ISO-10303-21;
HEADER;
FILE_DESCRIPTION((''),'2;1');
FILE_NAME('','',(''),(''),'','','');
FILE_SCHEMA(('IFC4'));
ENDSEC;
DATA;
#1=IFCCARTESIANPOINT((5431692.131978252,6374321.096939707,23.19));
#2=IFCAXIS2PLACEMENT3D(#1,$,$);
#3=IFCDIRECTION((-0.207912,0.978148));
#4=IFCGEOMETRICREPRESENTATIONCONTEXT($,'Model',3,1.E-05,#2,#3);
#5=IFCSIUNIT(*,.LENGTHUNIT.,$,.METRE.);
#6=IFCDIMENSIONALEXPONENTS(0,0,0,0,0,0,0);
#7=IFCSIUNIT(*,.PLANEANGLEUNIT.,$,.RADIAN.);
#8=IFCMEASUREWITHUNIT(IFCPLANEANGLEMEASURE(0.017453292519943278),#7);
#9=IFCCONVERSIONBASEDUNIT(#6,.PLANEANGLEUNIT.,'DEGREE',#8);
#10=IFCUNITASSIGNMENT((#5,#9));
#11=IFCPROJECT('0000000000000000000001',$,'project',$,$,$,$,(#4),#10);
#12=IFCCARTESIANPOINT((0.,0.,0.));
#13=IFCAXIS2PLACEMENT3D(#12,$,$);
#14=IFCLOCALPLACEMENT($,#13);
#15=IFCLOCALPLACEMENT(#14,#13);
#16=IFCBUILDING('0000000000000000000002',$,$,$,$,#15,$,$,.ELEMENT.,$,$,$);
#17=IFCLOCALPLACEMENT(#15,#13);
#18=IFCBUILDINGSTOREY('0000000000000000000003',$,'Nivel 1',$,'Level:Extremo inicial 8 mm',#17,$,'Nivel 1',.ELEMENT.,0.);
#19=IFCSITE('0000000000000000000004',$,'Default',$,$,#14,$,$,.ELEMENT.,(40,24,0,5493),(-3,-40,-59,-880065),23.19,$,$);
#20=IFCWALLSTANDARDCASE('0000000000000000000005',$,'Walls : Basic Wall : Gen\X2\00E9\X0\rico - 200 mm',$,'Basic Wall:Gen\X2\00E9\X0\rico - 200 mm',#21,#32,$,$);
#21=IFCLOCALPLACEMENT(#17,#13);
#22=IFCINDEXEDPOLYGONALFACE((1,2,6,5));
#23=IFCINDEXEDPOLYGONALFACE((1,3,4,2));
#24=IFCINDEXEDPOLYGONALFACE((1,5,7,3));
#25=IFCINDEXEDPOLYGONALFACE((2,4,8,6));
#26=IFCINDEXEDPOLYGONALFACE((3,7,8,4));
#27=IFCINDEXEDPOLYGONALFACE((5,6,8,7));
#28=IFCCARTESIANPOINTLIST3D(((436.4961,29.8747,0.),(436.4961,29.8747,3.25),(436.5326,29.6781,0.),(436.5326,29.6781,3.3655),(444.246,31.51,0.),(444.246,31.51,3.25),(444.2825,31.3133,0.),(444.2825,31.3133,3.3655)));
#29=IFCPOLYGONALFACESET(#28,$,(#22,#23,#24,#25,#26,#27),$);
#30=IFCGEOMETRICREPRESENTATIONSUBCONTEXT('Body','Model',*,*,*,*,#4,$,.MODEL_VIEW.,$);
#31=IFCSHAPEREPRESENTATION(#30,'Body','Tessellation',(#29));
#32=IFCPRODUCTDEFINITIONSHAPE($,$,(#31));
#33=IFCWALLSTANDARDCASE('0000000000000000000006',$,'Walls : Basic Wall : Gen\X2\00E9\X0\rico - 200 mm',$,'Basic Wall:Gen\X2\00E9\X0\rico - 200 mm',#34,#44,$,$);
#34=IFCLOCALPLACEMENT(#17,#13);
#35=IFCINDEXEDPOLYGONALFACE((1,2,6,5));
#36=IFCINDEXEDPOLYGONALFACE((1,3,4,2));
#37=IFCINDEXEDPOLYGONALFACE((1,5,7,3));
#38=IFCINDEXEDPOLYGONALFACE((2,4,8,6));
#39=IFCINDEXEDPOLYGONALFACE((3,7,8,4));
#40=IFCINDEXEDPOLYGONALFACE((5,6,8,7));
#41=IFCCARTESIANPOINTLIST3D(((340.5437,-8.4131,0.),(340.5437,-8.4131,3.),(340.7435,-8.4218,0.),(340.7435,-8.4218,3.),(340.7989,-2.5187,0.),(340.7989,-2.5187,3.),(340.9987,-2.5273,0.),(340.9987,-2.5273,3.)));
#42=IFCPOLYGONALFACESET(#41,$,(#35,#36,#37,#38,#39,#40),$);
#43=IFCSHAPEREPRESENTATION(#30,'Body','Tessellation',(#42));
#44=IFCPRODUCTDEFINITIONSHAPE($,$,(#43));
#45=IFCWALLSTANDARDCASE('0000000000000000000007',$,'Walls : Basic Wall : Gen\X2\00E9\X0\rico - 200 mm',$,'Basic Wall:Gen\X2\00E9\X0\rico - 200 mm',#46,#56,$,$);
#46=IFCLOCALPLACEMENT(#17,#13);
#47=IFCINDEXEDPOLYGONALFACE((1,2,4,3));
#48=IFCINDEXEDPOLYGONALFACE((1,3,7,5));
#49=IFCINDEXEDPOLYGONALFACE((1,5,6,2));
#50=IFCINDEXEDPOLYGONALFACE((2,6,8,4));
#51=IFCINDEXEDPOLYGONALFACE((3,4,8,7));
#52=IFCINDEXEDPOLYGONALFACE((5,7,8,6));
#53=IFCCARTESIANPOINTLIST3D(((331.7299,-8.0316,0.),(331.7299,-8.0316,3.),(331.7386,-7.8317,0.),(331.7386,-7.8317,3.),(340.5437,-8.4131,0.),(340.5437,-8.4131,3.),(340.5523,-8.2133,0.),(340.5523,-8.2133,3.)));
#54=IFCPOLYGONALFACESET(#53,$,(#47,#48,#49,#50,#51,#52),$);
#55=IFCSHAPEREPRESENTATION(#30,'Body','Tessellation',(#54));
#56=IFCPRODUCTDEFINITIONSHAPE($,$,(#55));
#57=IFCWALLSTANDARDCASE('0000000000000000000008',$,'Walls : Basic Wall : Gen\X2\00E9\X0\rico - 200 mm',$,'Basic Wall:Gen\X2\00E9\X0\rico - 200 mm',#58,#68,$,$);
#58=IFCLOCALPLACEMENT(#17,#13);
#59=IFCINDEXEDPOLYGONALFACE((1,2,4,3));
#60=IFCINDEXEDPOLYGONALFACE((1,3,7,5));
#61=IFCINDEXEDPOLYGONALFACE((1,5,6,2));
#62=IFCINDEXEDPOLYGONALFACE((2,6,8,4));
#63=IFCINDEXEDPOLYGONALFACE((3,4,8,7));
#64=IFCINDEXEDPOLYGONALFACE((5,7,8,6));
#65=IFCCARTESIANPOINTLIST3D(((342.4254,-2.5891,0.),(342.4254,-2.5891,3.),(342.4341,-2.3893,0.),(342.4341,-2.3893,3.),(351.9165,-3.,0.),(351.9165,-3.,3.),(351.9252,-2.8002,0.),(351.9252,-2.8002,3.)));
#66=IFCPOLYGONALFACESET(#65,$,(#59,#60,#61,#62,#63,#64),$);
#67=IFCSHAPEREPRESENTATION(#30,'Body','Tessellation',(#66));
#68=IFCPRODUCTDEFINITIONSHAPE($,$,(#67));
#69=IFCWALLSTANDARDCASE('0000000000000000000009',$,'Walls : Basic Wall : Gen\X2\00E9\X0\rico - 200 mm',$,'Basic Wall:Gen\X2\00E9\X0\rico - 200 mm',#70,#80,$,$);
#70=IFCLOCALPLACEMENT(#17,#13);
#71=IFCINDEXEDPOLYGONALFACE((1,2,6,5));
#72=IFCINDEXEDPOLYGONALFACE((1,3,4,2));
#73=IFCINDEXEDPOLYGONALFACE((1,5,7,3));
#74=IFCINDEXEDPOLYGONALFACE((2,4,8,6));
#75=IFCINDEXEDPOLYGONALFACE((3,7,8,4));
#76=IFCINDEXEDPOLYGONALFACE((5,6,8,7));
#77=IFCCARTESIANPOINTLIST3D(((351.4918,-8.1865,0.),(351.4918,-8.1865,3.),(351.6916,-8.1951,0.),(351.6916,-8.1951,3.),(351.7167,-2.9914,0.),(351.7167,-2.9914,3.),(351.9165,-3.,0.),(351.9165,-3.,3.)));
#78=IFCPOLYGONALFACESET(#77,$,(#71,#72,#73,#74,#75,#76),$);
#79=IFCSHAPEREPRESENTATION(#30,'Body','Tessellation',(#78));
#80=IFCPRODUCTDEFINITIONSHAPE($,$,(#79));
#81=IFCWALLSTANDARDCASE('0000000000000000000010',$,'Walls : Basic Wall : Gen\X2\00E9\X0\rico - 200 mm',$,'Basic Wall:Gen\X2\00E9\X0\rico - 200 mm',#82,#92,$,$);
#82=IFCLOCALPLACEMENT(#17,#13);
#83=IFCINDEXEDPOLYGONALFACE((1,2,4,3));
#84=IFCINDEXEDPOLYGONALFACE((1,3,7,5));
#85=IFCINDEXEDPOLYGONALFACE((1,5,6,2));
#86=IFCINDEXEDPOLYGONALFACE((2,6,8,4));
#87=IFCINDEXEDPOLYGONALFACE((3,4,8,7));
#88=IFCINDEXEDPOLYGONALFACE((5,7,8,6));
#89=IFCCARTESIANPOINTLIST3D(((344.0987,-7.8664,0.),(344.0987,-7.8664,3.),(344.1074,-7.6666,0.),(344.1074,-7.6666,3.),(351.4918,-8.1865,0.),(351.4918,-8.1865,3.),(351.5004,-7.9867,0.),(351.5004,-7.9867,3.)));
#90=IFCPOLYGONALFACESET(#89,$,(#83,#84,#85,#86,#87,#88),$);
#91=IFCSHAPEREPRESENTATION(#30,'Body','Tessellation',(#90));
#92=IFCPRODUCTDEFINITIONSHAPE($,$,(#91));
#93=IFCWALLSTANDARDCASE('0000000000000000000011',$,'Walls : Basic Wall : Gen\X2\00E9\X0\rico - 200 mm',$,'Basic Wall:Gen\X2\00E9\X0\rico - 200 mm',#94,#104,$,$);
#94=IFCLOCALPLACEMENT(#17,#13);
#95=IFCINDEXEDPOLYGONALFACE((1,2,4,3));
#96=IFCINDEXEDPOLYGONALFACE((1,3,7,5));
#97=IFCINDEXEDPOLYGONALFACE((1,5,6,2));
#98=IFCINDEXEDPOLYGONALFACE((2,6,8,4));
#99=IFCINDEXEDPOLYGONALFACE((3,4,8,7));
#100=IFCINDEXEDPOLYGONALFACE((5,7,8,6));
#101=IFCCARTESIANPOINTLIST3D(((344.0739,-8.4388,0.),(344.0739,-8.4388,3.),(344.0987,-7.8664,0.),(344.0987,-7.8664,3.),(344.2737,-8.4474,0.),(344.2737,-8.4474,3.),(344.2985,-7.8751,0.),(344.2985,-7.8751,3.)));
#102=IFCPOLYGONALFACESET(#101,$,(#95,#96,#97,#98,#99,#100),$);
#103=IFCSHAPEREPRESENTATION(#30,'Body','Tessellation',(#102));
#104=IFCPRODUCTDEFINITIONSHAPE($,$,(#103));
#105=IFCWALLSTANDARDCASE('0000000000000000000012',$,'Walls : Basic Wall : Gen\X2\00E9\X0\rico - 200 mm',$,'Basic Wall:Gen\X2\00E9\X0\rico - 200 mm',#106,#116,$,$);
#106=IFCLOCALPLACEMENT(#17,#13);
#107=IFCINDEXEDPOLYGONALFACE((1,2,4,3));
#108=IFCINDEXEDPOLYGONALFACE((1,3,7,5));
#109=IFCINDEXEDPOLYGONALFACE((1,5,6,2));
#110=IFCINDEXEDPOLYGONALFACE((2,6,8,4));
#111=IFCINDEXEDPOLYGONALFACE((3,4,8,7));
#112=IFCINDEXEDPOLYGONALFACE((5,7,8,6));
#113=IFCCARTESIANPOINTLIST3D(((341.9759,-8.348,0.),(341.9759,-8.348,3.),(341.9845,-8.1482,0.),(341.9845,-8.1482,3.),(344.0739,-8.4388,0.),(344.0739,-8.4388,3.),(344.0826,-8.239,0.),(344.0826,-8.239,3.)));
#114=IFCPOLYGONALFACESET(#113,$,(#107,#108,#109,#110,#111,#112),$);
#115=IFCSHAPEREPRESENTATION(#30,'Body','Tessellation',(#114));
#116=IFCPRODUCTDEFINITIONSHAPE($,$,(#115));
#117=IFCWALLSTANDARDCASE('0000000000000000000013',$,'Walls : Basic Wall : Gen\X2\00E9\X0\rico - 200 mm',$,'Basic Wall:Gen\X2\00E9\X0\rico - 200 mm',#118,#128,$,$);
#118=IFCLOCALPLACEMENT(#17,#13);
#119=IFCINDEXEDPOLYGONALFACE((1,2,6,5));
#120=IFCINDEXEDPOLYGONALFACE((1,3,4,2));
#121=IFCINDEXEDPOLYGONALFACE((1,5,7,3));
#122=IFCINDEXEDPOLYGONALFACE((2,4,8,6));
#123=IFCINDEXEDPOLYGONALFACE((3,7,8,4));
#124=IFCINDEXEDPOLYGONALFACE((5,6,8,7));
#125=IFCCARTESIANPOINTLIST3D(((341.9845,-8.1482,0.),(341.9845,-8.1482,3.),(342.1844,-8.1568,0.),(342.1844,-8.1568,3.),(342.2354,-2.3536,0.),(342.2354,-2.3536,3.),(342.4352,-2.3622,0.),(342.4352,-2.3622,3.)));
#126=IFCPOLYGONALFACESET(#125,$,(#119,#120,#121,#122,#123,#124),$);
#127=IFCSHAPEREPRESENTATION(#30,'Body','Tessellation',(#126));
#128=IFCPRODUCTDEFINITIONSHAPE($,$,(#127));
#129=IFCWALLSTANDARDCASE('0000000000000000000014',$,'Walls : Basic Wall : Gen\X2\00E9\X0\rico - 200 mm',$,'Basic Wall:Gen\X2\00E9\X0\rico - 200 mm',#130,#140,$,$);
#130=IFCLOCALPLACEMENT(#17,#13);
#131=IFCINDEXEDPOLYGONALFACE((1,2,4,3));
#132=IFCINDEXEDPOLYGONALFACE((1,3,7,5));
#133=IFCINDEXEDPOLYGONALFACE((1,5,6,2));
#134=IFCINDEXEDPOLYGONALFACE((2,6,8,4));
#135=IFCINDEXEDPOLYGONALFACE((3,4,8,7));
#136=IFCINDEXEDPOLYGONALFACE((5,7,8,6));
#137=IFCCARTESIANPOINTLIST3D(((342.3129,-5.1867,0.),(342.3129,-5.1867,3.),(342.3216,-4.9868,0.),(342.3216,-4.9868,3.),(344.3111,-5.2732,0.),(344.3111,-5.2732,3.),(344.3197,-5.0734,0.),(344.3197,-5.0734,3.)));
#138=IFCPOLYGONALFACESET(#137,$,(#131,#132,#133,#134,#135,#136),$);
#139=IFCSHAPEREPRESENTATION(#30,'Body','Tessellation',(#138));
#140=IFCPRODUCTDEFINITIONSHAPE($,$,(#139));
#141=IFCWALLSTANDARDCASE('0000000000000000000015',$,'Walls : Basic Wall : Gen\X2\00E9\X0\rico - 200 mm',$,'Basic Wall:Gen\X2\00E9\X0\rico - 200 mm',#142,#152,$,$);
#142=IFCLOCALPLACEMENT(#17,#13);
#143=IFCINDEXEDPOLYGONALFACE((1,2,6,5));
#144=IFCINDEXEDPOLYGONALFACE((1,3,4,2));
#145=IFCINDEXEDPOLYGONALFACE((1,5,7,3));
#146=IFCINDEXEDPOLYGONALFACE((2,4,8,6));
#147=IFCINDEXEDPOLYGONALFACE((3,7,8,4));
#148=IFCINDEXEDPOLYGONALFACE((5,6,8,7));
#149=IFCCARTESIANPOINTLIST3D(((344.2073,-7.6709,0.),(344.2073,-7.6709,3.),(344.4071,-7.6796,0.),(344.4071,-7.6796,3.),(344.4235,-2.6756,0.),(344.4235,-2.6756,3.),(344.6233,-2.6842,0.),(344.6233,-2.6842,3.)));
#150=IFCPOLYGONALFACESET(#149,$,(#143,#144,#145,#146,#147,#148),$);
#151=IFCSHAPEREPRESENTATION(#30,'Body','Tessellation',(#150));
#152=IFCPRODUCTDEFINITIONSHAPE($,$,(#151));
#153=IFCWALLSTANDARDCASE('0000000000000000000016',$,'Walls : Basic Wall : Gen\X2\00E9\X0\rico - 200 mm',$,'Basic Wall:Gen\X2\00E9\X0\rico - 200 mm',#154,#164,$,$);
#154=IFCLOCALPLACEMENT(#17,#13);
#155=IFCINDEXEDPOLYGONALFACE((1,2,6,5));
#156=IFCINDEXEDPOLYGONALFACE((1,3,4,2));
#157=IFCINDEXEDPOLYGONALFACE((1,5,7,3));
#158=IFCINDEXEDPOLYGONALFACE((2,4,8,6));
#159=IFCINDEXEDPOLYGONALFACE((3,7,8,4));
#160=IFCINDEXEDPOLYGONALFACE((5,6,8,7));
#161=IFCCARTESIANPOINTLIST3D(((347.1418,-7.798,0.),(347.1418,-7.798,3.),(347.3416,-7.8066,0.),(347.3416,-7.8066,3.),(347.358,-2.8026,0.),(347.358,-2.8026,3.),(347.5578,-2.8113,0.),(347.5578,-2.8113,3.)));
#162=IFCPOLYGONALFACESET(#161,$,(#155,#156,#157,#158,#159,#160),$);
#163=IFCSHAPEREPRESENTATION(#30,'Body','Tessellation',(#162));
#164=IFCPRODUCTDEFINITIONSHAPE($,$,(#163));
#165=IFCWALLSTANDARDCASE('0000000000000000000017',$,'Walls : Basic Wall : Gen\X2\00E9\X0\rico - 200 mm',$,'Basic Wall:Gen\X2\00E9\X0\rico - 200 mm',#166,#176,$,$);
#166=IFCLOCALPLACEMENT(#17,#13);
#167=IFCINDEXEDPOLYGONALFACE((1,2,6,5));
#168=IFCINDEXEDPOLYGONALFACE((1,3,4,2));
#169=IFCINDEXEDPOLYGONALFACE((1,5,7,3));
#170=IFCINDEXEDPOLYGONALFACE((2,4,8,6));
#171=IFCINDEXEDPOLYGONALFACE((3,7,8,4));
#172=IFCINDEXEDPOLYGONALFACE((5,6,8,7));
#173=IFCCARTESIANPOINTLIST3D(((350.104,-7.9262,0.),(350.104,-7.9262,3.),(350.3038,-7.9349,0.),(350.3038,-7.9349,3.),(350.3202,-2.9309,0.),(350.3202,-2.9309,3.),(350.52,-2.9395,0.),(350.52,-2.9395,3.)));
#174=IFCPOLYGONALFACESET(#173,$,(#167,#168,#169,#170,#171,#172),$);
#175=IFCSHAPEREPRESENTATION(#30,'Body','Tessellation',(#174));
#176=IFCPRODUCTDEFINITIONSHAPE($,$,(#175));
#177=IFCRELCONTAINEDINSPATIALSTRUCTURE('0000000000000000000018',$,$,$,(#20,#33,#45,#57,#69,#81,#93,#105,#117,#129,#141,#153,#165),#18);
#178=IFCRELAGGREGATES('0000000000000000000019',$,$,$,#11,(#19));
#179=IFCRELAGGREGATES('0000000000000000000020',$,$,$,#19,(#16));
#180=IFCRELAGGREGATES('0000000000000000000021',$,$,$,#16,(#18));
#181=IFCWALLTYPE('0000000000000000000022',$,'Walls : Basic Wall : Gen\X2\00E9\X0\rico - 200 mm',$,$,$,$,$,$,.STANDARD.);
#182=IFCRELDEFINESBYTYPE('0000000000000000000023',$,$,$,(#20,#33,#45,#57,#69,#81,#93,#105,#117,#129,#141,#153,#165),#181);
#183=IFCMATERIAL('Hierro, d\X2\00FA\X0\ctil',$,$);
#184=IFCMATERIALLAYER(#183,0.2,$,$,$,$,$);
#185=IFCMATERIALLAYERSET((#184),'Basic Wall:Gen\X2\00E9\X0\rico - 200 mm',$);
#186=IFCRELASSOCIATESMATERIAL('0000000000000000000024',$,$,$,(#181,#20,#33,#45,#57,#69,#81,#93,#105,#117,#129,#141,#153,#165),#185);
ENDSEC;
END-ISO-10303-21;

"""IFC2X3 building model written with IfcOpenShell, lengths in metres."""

from ifc_helpers import new_model, entity, si_unit, converted_unit, direction, frame, frame_2d, origin, place, context, subcontext, project, spatial, polyline, rectangle, outline, extrude, clip, bounded_halfspace, material, layer, layer_set, layer_usage, type_object, element, save


model = new_model("IFC2X3")

# Units and contexts
model_context = context("Model", 3, precision=1e-05, world=frame((5431692.131978252, 6374321.096939707, 23.19)), true_north=direction((-0.207912, 0.978148)))
body_context = subcontext(model_context, "Body", "Model", "MODEL_VIEW")
ifc_project = project(units=[si_unit("LENGTHUNIT", "METRE"), converted_unit("PLANEANGLEUNIT", "DEGREE", entity("IfcPlaneAngleMeasure", 0.017453292519943278), si_unit("PLANEANGLEUNIT", "RADIAN"), dimensions=[0, 0, 0, 0, 0, 0, 0])], contexts=[model_context])

# Site, building, storey
site_placement = place(None, origin())
site = spatial("IfcSite", under=ifc_project, at=site_placement, Name="Default", CompositionType="ELEMENT", RefLatitude=(40, 24, 0, 5493), RefLongitude=(-3, -40, -59, -880065), RefElevation=23.19)
building_placement = place(site_placement, origin())
building = spatial("IfcBuilding", under=site, at=building_placement, CompositionType="ELEMENT")
storey_placement = place(building_placement, origin())
storey = spatial("IfcBuildingStorey", under=building, at=storey_placement, Name="Nivel 1", ObjectType="Level:Extremo inicial 8 mm", LongName="Nivel 1", CompositionType="ELEMENT", Elevation=0.0)

# Walls
ifc_material_1 = material(Name="Hierro, dúctil")
ifc_layer_1 = layer(ifc_material_1, 0.2)
ifc_layer_set_1 = layer_set([ifc_layer_1], Name="Basic Wall:Genérico - 200 mm")
ifc_layer_usage_1 = layer_usage(ifc_layer_set_1, "AXIS2", "NEGATIVE", 0.1)
wall_type = type_object("IfcWallType", Name="Walls : Basic Wall : Genérico - 200 mm", PredefinedType="STANDARD", material=ifc_layer_set_1)
wall_1_placement = place(storey_placement, frame((436.512, 29.7759, 0.0), z_axis=(0.0, 0.0, 1.0), x_axis=(0.978457, 0.206451, 0.0)))
element("IfcWallStandardCase", 1, at=wall_1_placement, inside=storey, type_object=wall_type, material=ifc_layer_usage_1, Name="Walls : Basic Wall : Genérico - 200 mm", ObjectType="Basic Wall:Genérico - 200 mm", context=body_context, shape_type="Clipping", body=[
    clip(extrude(outline(polyline([(7.9205, -0.1), (7.9254, 0.1), (0.0049, 0.1), (0.0, -0.1), (7.7205, -0.1), (7.9205, -0.1)])), origin(), (0.0, 0.0, 1.0), 3.3655), bounded_halfspace(frame((0.0, -0.1, 3.3655), z_axis=(0.0, 0.5, 0.866025), x_axis=(-1.0, 0.0, 0.0)), False, frame((0.0, -0.1, 3.3655)), polyline([(0.0, 0.0), (7.7205, 0.0), (7.9205, 0.0), (7.9254, 0.2), (0.0049, 0.2), (0.0, 0.0)]))),
])
ifc_layer_usage_2 = layer_usage(ifc_layer_set_1, "AXIS2", "NEGATIVE", 0.1)
wall_2_placement = place(storey_placement, frame((340.8988, -2.523, 0.0), z_axis=(0.0, 0.0, 1.0), x_axis=(-0.043255, -0.999064, 0.0)))
element("IfcWallStandardCase", 2, at=wall_2_placement, inside=storey, type_object=wall_type, material=ifc_layer_usage_2, Name="Walls : Basic Wall : Genérico - 200 mm", ObjectType="Basic Wall:Genérico - 200 mm", context=body_context, shape_type="SweptSolid", body=[
    extrude(rectangle(XDim=5.9, YDim=0.2, at=frame_2d((2.95, 0.0), x_axis=(-1.0, 0.0))), origin(), (0.0, 0.0, 1.0), 3.0),
])
ifc_layer_usage_3 = layer_usage(ifc_layer_set_1, "AXIS2", "NEGATIVE", 0.1)
wall_3_placement = place(storey_placement, frame((340.548, -8.3132, 0.0), z_axis=(0.0, 0.0, 1.0), x_axis=(-0.999064, 0.043255, 0.0)))
element("IfcWallStandardCase", 3, at=wall_3_placement, inside=storey, type_object=wall_type, material=ifc_layer_usage_3, Name="Walls : Basic Wall : Genérico - 200 mm", ObjectType="Basic Wall:Genérico - 200 mm", context=body_context, shape_type="SweptSolid", body=[
    extrude(rectangle(XDim=8.822, YDim=0.2, at=frame_2d((4.411, 0.0), x_axis=(-1.0, 0.0))), origin(), (0.0, 0.0, 1.0), 3.0),
])
ifc_layer_usage_4 = layer_usage(ifc_layer_set_1, "AXIS2", "NEGATIVE", 0.1)
wall_4_placement = place(storey_placement, frame((342.4297, -2.4892, 0.0), z_axis=(0.0, 0.0, 1.0), x_axis=(0.999064, -0.043255, 0.0)))
element("IfcWallStandardCase", 4, at=wall_4_placement, inside=storey, type_object=wall_type, material=ifc_layer_usage_4, Name="Walls : Basic Wall : Genérico - 200 mm", ObjectType="Basic Wall:Genérico - 200 mm", context=body_context, shape_type="SweptSolid", body=[
    extrude(rectangle(XDim=9.5, YDim=0.2, at=frame_2d((4.75, 0.0), x_axis=(-1.0, 0.0))), origin(), (0.0, 0.0, 1.0), 3.0),
])
ifc_layer_usage_5 = layer_usage(ifc_layer_set_1, "AXIS2", "NEGATIVE", 0.1)
wall_5_placement = place(storey_placement, frame((351.8166, -2.9957, 0.0), z_axis=(0.0, 0.0, 1.0), x_axis=(-0.043255, -0.999064, 0.0)))
element("IfcWallStandardCase", 5, at=wall_5_placement, inside=storey, type_object=wall_type, material=ifc_layer_usage_5, Name="Walls : Basic Wall : Genérico - 200 mm", ObjectType="Basic Wall:Genérico - 200 mm", context=body_context, shape_type="SweptSolid", body=[
    extrude(rectangle(XDim=5.2, YDim=0.2, at=frame_2d((2.6, 0.0), x_axis=(-1.0, 0.0))), origin(), (0.0, 0.0, 1.0), 3.0),
])
ifc_layer_usage_6 = layer_usage(ifc_layer_set_1, "AXIS2", "NEGATIVE", 0.1)
wall_6_placement = place(storey_placement, frame((351.4961, -8.0866, 0.0), z_axis=(0.0, 0.0, 1.0), x_axis=(-0.999064, 0.043255, 0.0)))
element("IfcWallStandardCase", 6, at=wall_6_placement, inside=storey, type_object=wall_type, material=ifc_layer_usage_6, Name="Walls : Basic Wall : Genérico - 200 mm", ObjectType="Basic Wall:Genérico - 200 mm", context=body_context, shape_type="SweptSolid", body=[
    extrude(rectangle(XDim=7.4, YDim=0.2, at=frame_2d((3.7, 0.0), x_axis=(-1.0, 0.0))), origin(), (0.0, 0.0, 1.0), 3.0),
])
ifc_layer_usage_7 = layer_usage(ifc_layer_set_1, "AXIS2", "NEGATIVE", 0.1)
wall_7_placement = place(storey_placement, frame((344.1986, -7.8707, 0.0), z_axis=(0.0, 0.0, 1.0), x_axis=(-0.043255, -0.999064, 0.0)))
element("IfcWallStandardCase", 7, at=wall_7_placement, inside=storey, type_object=wall_type, material=ifc_layer_usage_7, Name="Walls : Basic Wall : Genérico - 200 mm", ObjectType="Basic Wall:Genérico - 200 mm", context=body_context, shape_type="SweptSolid", body=[
    extrude(rectangle(XDim=0.5729, YDim=0.2, at=frame_2d((0.2865, 0.0), x_axis=(-1.0, 0.0))), origin(), (0.0, 0.0, 1.0), 3.0),
])
ifc_layer_usage_8 = layer_usage(ifc_layer_set_1, "AXIS2", "NEGATIVE", 0.1)
wall_8_placement = place(storey_placement, frame((344.0782, -8.3389, 0.0), z_axis=(0.0, 0.0, 1.0), x_axis=(-0.999064, 0.043255, 0.0)))
element("IfcWallStandardCase", 8, at=wall_8_placement, inside=storey, type_object=wall_type, material=ifc_layer_usage_8, Name="Walls : Basic Wall : Genérico - 200 mm", ObjectType="Basic Wall:Genérico - 200 mm", context=body_context, shape_type="SweptSolid", body=[
    extrude(rectangle(XDim=2.1, YDim=0.2, at=frame_2d((1.05, 0.0), x_axis=(-1.0, 0.0))), origin(), (0.0, 0.0, 1.0), 3.0),
])
ifc_layer_usage_9 = layer_usage(ifc_layer_set_1, "AXIS2", "NEGATIVE", 0.1)
wall_9_placement = place(storey_placement, frame((342.0844, -8.1525, 0.0), z_axis=(0.0, 0.0, 1.0), x_axis=(0.043255, 0.999064, 0.0)))
element("IfcWallStandardCase", 9, at=wall_9_placement, inside=storey, type_object=wall_type, material=ifc_layer_usage_9, Name="Walls : Basic Wall : Genérico - 200 mm", ObjectType="Basic Wall:Genérico - 200 mm", context=body_context, shape_type="SweptSolid", body=[
    extrude(rectangle(XDim=5.8, YDim=0.2, at=frame_2d((2.9, 0.0), x_axis=(-1.0, 0.0))), origin(), (0.0, 0.0, 1.0), 3.0),
])
ifc_layer_usage_10 = layer_usage(ifc_layer_set_1, "AXIS2", "NEGATIVE", 0.1)
wall_10_placement = place(storey_placement, frame((342.3173, -5.0867, 0.0), z_axis=(0.0, 0.0, 1.0), x_axis=(0.999064, -0.043255, 0.0)))
element("IfcWallStandardCase", 10, at=wall_10_placement, inside=storey, type_object=wall_type, material=ifc_layer_usage_10, Name="Walls : Basic Wall : Genérico - 200 mm", ObjectType="Basic Wall:Genérico - 200 mm", context=body_context, shape_type="SweptSolid", body=[
    extrude(rectangle(XDim=2.0, YDim=0.2, at=frame_2d((1.0, 0.0), x_axis=(-1.0, 0.0))), origin(), (0.0, 0.0, 1.0), 3.0),
])
ifc_layer_usage_11 = layer_usage(ifc_layer_set_1, "AXIS2", "NEGATIVE", 0.1)
wall_11_placement = place(storey_placement, frame((344.5234, -2.6799, 0.0), z_axis=(0.0, 0.0, 1.0), x_axis=(-0.043255, -0.999064, 0.0)))
element("IfcWallStandardCase", 11, at=wall_11_placement, inside=storey, type_object=wall_type, material=ifc_layer_usage_11, Name="Walls : Basic Wall : Genérico - 200 mm", ObjectType="Basic Wall:Genérico - 200 mm", context=body_context, shape_type="SweptSolid", body=[
    extrude(rectangle(XDim=5.0, YDim=0.2, at=frame_2d((2.5, 0.0), x_axis=(-1.0, 0.0))), origin(), (0.0, 0.0, 1.0), 3.0),
])
ifc_layer_usage_12 = layer_usage(ifc_layer_set_1, "AXIS2", "NEGATIVE", 0.1)
wall_12_placement = place(storey_placement, frame((347.2417, -7.8023, 0.0), z_axis=(0.0, 0.0, 1.0), x_axis=(0.043255, 0.999064, 0.0)))
element("IfcWallStandardCase", 12, at=wall_12_placement, inside=storey, type_object=wall_type, material=ifc_layer_usage_12, Name="Walls : Basic Wall : Genérico - 200 mm", ObjectType="Basic Wall:Genérico - 200 mm", context=body_context, shape_type="SweptSolid", body=[
    extrude(rectangle(XDim=5.0, YDim=0.2, at=frame_2d((2.5, 0.0), x_axis=(-1.0, 0.0))), origin(), (0.0, 0.0, 1.0), 3.0),
])
ifc_layer_usage_13 = layer_usage(ifc_layer_set_1, "AXIS2", "NEGATIVE", 0.1)
wall_13_placement = place(storey_placement, frame((350.4201, -2.9352, 0.0), z_axis=(0.0, 0.0, 1.0), x_axis=(-0.043255, -0.999064, 0.0)))
element("IfcWallStandardCase", 13, at=wall_13_placement, inside=storey, type_object=wall_type, material=ifc_layer_usage_13, Name="Walls : Basic Wall : Genérico - 200 mm", ObjectType="Basic Wall:Genérico - 200 mm", context=body_context, shape_type="SweptSolid", body=[
    extrude(rectangle(XDim=5.0, YDim=0.2, at=frame_2d((2.5, 0.0), x_axis=(-1.0, 0.0))), origin(), (0.0, 0.0, 1.0), 3.0),
])

save(model, "model.ifc")
